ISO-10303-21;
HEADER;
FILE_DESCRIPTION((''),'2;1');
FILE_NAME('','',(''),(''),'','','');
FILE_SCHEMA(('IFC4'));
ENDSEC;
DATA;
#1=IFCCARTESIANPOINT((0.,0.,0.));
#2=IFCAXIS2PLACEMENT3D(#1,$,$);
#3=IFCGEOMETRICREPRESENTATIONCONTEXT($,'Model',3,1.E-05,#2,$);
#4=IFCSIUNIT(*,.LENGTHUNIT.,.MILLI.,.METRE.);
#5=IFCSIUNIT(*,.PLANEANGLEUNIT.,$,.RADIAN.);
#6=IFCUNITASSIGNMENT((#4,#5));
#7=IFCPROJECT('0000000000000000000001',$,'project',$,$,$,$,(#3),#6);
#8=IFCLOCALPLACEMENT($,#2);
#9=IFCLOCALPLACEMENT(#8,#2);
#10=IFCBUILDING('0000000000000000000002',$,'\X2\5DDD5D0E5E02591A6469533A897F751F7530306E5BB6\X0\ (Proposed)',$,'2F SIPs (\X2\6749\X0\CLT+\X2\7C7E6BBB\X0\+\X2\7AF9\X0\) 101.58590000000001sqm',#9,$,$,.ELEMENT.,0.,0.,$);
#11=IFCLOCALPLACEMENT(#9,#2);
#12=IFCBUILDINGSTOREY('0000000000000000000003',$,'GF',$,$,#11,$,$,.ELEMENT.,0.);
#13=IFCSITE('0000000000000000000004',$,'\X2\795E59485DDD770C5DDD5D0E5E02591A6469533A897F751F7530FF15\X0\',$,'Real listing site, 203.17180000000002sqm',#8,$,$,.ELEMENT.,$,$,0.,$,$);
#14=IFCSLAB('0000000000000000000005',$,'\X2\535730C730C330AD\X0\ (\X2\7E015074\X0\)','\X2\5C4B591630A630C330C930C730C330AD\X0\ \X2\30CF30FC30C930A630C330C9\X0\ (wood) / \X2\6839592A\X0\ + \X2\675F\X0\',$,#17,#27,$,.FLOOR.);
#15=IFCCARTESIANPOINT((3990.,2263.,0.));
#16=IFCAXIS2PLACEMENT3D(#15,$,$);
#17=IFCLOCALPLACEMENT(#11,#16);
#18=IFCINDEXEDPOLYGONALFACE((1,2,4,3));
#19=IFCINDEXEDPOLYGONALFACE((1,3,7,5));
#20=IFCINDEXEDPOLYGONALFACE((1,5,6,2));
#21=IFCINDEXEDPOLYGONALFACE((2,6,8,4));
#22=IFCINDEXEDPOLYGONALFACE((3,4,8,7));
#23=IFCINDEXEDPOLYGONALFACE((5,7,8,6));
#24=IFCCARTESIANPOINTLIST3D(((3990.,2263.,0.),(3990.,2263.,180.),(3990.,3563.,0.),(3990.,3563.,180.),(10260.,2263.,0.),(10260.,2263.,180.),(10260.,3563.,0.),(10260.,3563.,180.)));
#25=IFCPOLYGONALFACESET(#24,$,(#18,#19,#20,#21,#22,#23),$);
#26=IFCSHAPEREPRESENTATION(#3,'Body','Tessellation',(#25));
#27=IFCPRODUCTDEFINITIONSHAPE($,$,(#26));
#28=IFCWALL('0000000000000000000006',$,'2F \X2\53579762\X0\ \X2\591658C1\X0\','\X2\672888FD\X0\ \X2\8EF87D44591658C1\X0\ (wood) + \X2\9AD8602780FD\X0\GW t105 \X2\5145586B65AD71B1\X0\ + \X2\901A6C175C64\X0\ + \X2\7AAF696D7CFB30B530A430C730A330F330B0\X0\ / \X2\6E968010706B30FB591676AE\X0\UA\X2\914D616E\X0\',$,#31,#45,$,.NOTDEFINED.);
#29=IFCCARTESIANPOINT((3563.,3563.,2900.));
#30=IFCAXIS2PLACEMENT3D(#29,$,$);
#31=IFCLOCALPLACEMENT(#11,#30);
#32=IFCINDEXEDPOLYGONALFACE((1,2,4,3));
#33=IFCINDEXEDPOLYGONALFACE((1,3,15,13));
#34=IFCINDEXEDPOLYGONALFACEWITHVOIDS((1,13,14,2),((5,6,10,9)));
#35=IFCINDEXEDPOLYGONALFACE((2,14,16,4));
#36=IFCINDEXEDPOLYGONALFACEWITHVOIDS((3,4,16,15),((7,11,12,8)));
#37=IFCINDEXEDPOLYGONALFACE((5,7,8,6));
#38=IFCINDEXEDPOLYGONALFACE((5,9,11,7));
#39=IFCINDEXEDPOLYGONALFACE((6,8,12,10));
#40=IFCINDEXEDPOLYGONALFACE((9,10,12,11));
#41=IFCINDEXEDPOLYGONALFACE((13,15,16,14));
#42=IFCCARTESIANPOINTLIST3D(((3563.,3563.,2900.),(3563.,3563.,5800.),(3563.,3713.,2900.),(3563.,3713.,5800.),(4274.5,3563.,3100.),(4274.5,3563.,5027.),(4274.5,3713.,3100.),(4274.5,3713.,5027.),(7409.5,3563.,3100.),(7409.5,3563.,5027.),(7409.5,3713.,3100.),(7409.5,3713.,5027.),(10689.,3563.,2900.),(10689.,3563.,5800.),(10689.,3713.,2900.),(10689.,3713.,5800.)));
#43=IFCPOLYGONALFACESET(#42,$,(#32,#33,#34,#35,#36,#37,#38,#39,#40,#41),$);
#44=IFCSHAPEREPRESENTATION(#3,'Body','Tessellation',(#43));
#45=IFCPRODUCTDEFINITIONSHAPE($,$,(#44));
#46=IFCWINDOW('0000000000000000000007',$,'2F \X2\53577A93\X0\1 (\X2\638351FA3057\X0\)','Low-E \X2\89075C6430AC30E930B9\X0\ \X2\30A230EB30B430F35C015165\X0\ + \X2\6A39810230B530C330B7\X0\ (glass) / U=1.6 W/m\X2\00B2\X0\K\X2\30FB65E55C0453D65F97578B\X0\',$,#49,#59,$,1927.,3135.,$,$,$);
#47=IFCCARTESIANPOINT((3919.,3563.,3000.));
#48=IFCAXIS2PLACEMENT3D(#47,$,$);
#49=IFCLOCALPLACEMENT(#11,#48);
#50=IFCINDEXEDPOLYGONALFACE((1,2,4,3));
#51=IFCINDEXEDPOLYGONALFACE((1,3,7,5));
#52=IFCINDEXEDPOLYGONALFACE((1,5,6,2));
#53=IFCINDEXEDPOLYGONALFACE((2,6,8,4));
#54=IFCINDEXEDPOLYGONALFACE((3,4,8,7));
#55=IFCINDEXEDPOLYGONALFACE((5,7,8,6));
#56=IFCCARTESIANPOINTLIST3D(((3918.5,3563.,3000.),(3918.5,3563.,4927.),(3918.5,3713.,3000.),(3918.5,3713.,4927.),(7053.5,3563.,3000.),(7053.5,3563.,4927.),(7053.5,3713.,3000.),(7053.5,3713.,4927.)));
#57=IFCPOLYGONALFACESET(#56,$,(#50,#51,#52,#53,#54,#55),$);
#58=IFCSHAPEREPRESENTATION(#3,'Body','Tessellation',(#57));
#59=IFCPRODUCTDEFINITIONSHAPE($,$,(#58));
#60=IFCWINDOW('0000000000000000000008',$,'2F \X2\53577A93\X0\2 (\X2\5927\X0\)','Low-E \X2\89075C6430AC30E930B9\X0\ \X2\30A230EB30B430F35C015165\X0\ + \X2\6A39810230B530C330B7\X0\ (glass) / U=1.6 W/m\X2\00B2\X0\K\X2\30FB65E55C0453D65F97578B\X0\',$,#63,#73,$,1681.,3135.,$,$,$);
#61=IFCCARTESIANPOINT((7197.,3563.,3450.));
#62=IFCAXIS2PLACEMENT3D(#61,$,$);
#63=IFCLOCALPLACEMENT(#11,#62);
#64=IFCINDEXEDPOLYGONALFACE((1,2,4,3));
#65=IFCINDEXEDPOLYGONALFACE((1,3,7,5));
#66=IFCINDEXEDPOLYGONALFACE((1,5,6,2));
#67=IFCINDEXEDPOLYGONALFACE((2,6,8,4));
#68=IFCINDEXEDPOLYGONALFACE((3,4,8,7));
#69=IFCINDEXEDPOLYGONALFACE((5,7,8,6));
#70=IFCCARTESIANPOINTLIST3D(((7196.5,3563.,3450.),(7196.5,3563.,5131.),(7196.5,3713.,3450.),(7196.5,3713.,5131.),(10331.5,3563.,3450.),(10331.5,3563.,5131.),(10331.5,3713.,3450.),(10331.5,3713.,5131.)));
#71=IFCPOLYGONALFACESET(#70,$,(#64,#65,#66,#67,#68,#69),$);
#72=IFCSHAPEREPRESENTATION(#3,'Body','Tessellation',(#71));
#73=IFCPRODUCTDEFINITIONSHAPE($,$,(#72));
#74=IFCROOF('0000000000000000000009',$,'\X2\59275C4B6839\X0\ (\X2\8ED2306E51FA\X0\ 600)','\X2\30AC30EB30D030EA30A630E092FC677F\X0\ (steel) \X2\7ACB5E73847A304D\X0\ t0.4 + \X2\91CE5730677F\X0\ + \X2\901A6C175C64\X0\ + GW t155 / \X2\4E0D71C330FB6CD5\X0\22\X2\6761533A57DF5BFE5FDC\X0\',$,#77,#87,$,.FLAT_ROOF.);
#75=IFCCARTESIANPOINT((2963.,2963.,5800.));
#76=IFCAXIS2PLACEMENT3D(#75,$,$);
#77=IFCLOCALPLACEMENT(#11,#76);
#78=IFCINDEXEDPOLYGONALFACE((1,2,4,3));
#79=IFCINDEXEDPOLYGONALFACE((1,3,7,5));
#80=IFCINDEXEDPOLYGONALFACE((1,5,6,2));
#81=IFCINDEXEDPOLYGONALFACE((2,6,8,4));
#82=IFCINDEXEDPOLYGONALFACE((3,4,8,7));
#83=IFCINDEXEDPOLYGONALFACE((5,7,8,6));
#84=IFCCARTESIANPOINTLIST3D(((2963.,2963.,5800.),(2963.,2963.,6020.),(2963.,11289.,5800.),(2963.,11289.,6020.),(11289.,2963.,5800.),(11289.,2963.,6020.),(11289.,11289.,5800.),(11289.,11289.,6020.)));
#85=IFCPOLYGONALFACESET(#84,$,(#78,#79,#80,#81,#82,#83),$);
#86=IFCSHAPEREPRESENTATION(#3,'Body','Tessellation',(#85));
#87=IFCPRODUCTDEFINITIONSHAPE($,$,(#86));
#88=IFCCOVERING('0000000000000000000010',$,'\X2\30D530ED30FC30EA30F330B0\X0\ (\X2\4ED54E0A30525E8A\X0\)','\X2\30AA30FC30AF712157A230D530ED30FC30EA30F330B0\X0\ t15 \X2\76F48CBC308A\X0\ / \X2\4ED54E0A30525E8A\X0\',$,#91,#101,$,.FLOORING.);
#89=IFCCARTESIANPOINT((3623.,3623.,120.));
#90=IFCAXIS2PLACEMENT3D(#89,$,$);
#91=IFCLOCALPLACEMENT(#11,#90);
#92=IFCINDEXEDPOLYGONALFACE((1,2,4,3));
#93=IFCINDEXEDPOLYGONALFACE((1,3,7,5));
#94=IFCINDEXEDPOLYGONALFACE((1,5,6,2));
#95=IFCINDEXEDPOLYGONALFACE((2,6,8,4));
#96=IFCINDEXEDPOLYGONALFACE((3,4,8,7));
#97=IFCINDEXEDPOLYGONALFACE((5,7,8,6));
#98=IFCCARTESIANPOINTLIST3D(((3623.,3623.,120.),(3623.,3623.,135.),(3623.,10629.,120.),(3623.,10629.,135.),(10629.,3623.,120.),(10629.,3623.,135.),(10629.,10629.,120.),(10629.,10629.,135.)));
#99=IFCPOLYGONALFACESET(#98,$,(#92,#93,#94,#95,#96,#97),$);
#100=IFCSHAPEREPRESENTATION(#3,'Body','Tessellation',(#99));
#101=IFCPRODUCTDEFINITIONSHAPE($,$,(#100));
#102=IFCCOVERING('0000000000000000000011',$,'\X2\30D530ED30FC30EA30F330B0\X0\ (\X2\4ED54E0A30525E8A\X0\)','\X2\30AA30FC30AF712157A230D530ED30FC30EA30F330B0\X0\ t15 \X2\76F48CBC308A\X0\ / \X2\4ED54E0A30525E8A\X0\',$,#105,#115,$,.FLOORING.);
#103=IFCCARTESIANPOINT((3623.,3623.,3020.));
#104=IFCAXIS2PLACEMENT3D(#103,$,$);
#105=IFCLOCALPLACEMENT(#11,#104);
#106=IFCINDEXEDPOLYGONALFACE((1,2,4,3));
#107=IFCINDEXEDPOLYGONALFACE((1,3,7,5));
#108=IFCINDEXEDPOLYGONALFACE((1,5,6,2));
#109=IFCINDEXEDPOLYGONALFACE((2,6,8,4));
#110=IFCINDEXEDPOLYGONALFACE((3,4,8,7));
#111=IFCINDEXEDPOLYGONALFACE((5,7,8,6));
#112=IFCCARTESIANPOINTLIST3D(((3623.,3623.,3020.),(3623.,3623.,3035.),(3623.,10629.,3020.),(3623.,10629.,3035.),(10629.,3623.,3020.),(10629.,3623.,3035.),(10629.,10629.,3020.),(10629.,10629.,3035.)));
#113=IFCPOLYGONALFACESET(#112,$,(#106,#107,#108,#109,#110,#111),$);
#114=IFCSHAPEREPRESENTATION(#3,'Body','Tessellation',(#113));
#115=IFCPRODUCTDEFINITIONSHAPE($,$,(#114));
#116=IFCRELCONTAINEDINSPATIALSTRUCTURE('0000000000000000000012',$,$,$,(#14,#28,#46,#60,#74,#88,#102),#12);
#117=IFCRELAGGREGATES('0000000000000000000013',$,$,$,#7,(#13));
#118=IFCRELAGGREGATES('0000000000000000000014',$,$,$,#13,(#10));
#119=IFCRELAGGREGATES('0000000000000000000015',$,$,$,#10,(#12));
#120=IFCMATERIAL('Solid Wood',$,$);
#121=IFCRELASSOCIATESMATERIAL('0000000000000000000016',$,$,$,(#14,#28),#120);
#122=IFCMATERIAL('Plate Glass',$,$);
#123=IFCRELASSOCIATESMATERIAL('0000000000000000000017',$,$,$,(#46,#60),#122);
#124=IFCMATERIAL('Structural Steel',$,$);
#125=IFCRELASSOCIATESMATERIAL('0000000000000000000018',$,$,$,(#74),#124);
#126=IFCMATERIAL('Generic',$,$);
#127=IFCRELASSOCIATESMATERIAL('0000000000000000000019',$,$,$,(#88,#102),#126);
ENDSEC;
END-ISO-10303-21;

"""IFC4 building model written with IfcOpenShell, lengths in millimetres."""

from ifc_helpers import new_model, si_unit, frame, frame_2d, origin, place, context, project, spatial, rectangle, extrude, material, element, fill, save


model = new_model("IFC4")

# Units and contexts
model_context = context("Model", 3, precision=1e-05, world=origin())
ifc_project = project(units=[si_unit("LENGTHUNIT", "METRE", prefix="MILLI"), si_unit("PLANEANGLEUNIT", "RADIAN")], contexts=[model_context])

# Site, building, storey
site_placement = place(None, origin())
site = spatial("IfcSite", under=ifc_project, at=site_placement, Name="神奈川県川崎市多摩区西生田５", ObjectType="Real listing site, 203.17180000000002sqm", CompositionType="ELEMENT", RefElevation=0.0)
building_placement = place(site_placement, origin())
building = spatial("IfcBuilding", under=site, at=building_placement, Name="川崎市多摩区西生田の家 (Proposed)", ObjectType="2F SIPs (杉CLT+籾殻+竹) 101.58590000000001sqm", CompositionType="ELEMENT", ElevationOfRefHeight=0.0, ElevationOfTerrain=0.0)
storey_placement = place(building_placement, origin())
storey = spatial("IfcBuildingStorey", under=building, at=storey_placement, Name="GF", CompositionType="ELEMENT", Elevation=0.0)

# Slab
ifc_material_1 = material(Name="Solid Wood")
slab_1_placement = place(storey_placement, frame((3990.0, 2263.0, 0.0)))
element("IfcSlab", 1, at=slab_1_placement, inside=storey, material=ifc_material_1, Name="南デッキ (縁側)", Description="屋外ウッドデッキ ハードウッド (wood) / 根太 + 束", PredefinedType="FLOOR", context=model_context, shape_type="SweptSolid", body=[
    extrude(rectangle(XDim=6270.0, YDim=1300.0, at=frame_2d((3135.0, 650.0))), frame((3990.0, 2263.0, 0.0)), (0.0, 0.0, 1.0), 180.0),
])

# Shared definitions
ifc_material_2 = material(Name="Plate Glass")

# Wall, openings, windows
wall_1_placement = place(storey_placement, frame((3563.0, 3563.0, 2900.0)))
wall_1 = element("IfcWall", 2, at=wall_1_placement, inside=storey, material=ifc_material_1, Name="2F 南面 外壁", Description="木製 軸組外壁 (wood) + 高性能GW t105 充填断熱 + 通気層 + 窯業系サイディング / 準耐火・外皮UA配慮", PredefinedType="NOTDEFINED", context=model_context, shape_type="SweptSolid", body=[
    extrude(rectangle(XDim=7126.0, YDim=150.0, at=frame_2d((3563.0, 75.0))), frame((3563.0, 3563.0, 2900.0)), (0.0, 0.0, 1.0), 2900.0),
])
opening_1_placement = place(storey_placement, frame((3919.0, 3563.0, 3000.0)))
opening_1 = element("IfcOpeningElement", 3, at=opening_1_placement, cuts=wall_1, PredefinedType="NOTDEFINED", context=model_context, shape_type="SweptSolid", body=[
    extrude(rectangle(XDim=3135.0, YDim=150.0, at=frame_2d((1567.0, 75.0))), frame((3919.0, 3563.0, 3000.0)), (0.0, 0.0, 1.0), 1927.0),
])
opening_2_placement = place(storey_placement, frame((7197.0, 3563.0, 3450.0)))
opening_2 = element("IfcOpeningElement", 4, at=opening_2_placement, cuts=wall_1, PredefinedType="NOTDEFINED", context=model_context, shape_type="SweptSolid", body=[
    extrude(rectangle(XDim=3135.0, YDim=150.0, at=frame_2d((1567.0, 75.0))), frame((7197.0, 3563.0, 3450.0)), (0.0, 0.0, 1.0), 1681.0),
])
window_1_placement = place(storey_placement, frame((3919.0, 3563.0, 3000.0)))
window_1 = element("IfcWindow", 5, at=window_1_placement, inside=storey, material=ifc_material_2, Name="2F 南窓1 (掃出し)", Description="Low-E 複層ガラス アルゴン封入 + 樹脂サッシ (glass) / U=1.6 W/m²K・日射取得型", OverallHeight=1927.0, OverallWidth=3135.0, context=model_context, shape_type="SweptSolid", body=[
    extrude(rectangle(XDim=3135.0, YDim=150.0, at=frame_2d((1567.0, 75.0))), frame((3919.0, 3563.0, 3000.0)), (0.0, 0.0, 1.0), 1927.0),
])
fill(opening_1, window_1)
window_2_placement = place(storey_placement, frame((7197.0, 3563.0, 3450.0)))
window_2 = element("IfcWindow", 6, at=window_2_placement, inside=storey, material=ifc_material_2, Name="2F 南窓2 (大)", Description="Low-E 複層ガラス アルゴン封入 + 樹脂サッシ (glass) / U=1.6 W/m²K・日射取得型", OverallHeight=1681.0, OverallWidth=3135.0, context=model_context, shape_type="SweptSolid", body=[
    extrude(rectangle(XDim=3135.0, YDim=150.0, at=frame_2d((1567.0, 75.0))), frame((7197.0, 3563.0, 3450.0)), (0.0, 0.0, 1.0), 1681.0),
])
fill(opening_2, window_2)

# Roof
ifc_material_3 = material(Name="Structural Steel")
roof_placement = place(storey_placement, frame((2963.0, 2963.0, 5800.0)))
element("IfcRoof", 7, at=roof_placement, inside=storey, material=ifc_material_3, Name="大屋根 (軒の出 600)", Description="ガルバリウム鋼板 (steel) 立平葺き t0.4 + 野地板 + 通気層 + GW t155 / 不燃・法22条区域対応", PredefinedType="FLAT_ROOF", context=model_context, shape_type="SweptSolid", body=[
    extrude(rectangle(XDim=8326.0, YDim=8326.0, at=frame_2d((4163.0, 4163.0))), frame((2963.0, 2963.0, 5800.0)), (0.0, 0.0, 1.0), 220.0),
])

# Coverings
ifc_material_4 = material(Name="Generic")
covering_1_placement = place(storey_placement, frame((3623.0, 3623.0, 120.0)))
element("IfcCovering", 8, at=covering_1_placement, inside=storey, material=ifc_material_4, Name="フローリング (仕上げ床)", Description="オーク無垢フローリング t15 直貼り / 仕上げ床", PredefinedType="FLOORING", context=model_context, shape_type="SweptSolid", body=[
    extrude(rectangle(XDim=7006.0, YDim=7006.0, at=frame_2d((3503.0, 3503.0))), frame((3623.0, 3623.0, 120.0)), (0.0, 0.0, 1.0), 15.0),
])
covering_2_placement = place(storey_placement, frame((3623.0, 3623.0, 3020.0)))
element("IfcCovering", 9, at=covering_2_placement, inside=storey, material=ifc_material_4, Name="フローリング (仕上げ床)", Description="オーク無垢フローリング t15 直貼り / 仕上げ床", PredefinedType="FLOORING", context=model_context, shape_type="SweptSolid", body=[
    extrude(rectangle(XDim=7006.0, YDim=7006.0, at=frame_2d((3503.0, 3503.0))), frame((3623.0, 3623.0, 3020.0)), (0.0, 0.0, 1.0), 15.0),
])

save(model, "model.ifc")
